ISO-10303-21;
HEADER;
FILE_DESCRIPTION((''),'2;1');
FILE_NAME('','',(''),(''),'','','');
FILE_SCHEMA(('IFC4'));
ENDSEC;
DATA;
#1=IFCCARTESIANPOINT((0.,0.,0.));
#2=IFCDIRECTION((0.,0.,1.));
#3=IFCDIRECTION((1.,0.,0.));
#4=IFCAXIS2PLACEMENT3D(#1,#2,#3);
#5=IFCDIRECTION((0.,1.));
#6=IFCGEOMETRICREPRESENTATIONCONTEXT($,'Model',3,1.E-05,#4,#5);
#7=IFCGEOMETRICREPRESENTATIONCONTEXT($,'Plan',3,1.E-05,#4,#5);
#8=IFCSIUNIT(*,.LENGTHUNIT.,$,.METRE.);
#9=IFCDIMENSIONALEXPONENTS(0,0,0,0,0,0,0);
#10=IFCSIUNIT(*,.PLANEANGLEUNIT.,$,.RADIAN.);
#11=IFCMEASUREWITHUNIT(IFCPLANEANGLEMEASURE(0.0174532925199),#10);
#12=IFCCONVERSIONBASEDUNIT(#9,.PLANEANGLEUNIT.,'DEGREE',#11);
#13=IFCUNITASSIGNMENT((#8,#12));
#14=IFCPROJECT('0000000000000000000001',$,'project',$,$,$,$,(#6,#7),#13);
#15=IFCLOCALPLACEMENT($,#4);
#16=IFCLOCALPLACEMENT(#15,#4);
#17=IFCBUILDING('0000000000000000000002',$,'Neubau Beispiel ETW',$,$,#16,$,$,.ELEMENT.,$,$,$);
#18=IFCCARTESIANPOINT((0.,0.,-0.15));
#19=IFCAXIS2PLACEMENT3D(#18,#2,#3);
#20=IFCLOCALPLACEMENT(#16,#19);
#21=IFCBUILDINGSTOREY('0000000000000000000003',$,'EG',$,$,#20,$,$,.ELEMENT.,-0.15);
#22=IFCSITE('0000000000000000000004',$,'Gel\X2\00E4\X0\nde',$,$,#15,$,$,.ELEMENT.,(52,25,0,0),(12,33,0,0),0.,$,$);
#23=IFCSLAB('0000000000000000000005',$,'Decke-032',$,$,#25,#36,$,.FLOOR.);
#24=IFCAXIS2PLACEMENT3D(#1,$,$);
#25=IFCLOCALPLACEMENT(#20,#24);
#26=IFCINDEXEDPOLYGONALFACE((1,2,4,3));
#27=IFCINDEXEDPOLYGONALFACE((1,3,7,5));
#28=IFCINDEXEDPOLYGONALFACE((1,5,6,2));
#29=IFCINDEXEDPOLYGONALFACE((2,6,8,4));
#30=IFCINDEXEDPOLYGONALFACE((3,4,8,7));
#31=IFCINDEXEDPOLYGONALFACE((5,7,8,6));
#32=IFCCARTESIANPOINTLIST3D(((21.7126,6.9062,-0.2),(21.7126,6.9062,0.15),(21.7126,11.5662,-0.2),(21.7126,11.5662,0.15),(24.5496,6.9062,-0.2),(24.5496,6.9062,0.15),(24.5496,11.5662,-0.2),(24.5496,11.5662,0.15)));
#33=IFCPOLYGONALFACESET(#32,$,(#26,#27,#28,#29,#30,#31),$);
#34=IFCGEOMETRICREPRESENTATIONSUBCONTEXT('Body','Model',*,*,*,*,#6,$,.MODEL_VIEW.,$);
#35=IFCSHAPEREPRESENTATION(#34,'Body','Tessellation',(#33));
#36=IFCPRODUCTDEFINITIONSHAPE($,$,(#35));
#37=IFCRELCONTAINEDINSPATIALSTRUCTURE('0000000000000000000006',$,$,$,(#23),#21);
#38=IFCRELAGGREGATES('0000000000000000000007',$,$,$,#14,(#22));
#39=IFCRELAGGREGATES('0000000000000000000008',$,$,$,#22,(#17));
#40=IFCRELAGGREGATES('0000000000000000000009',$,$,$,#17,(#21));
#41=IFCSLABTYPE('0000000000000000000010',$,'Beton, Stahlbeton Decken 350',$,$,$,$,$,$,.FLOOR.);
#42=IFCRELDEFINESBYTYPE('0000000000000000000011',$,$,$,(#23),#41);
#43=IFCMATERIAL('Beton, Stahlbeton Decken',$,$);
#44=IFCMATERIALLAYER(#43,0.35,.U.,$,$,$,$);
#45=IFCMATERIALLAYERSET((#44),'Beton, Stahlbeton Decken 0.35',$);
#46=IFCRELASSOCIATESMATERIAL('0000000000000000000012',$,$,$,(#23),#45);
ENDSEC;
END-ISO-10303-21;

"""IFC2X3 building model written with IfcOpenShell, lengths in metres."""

from ifc_helpers import new_model, entity, si_unit, converted_unit, direction, frame, origin_with_axes, place, context, subcontext, project, spatial, polyline, outline, extrude, material, layer, layer_set, layer_usage, type_object, element, save


model = new_model("IFC2X3")

# Units and contexts
model_context = context("Model", 3, precision=1e-05, world=origin_with_axes(), true_north=direction((0.0, 1.0)))
plan_context = context("Plan", 3, precision=1e-05, world=origin_with_axes(), true_north=direction((0.0, 1.0)))
body_context = subcontext(model_context, "Body", "Model", "MODEL_VIEW")
ifc_project = project(units=[si_unit("LENGTHUNIT", "METRE"), converted_unit("PLANEANGLEUNIT", "DEGREE", entity("IfcPlaneAngleMeasure", 0.0174532925199), si_unit("PLANEANGLEUNIT", "RADIAN"), dimensions=[0, 0, 0, 0, 0, 0, 0])], contexts=[model_context, plan_context])

# Site, building, storey
site_placement = place(None, origin_with_axes())
site = spatial("IfcSite", under=ifc_project, at=site_placement, Name="Gelände", CompositionType="ELEMENT", RefLatitude=(52, 25, 0, 0), RefLongitude=(12, 33, 0, 0), RefElevation=0.0)
building_placement = place(site_placement, origin_with_axes())
building = spatial("IfcBuilding", under=site, at=building_placement, Name="Neubau Beispiel ETW", CompositionType="ELEMENT")
storey_placement = place(building_placement, frame((0.0, 0.0, -0.15), z_axis=(0.0, 0.0, 1.0), x_axis=(1.0, 0.0, 0.0)))
storey = spatial("IfcBuildingStorey", under=building, at=storey_placement, Name="EG", CompositionType="ELEMENT", Elevation=-0.15)

# Slab
ifc_material = material(Name="Beton, Stahlbeton Decken")
ifc_layer = layer(ifc_material, 0.35, ventilated="UNKNOWN")
ifc_layer_set = layer_set([ifc_layer], Name="Beton, Stahlbeton Decken 0.35")
ifc_layer_usage = layer_usage(ifc_layer_set, "AXIS3", "NEGATIVE", 0.35)
slab_type = type_object("IfcSlabType", Name="Beton, Stahlbeton Decken 350", PredefinedType="FLOOR")
slab_placement = place(storey_placement, frame((21.7126, 11.5662, 0.15), z_axis=(0.0, 0.0, 1.0), x_axis=(1.0, 0.0, 0.0)))
element("IfcSlab", 1, at=slab_placement, inside=storey, type_object=slab_type, material=ifc_layer_usage, Name="Decke-032", PredefinedType="FLOOR", context=body_context, shape_type="SweptSolid", body=[
    extrude(outline(polyline([(0.0, 0.0), (0.0, -4.66), (2.837, -4.66), (2.837, 0.0), (0.0, 0.0)])), frame((0.0, 0.0, -0.35), z_axis=(0.0, 0.0, 1.0), x_axis=(1.0, 0.0, 0.0)), (0.0, 0.0, 1.0), 0.35),
])

save(model, "model.ifc")
